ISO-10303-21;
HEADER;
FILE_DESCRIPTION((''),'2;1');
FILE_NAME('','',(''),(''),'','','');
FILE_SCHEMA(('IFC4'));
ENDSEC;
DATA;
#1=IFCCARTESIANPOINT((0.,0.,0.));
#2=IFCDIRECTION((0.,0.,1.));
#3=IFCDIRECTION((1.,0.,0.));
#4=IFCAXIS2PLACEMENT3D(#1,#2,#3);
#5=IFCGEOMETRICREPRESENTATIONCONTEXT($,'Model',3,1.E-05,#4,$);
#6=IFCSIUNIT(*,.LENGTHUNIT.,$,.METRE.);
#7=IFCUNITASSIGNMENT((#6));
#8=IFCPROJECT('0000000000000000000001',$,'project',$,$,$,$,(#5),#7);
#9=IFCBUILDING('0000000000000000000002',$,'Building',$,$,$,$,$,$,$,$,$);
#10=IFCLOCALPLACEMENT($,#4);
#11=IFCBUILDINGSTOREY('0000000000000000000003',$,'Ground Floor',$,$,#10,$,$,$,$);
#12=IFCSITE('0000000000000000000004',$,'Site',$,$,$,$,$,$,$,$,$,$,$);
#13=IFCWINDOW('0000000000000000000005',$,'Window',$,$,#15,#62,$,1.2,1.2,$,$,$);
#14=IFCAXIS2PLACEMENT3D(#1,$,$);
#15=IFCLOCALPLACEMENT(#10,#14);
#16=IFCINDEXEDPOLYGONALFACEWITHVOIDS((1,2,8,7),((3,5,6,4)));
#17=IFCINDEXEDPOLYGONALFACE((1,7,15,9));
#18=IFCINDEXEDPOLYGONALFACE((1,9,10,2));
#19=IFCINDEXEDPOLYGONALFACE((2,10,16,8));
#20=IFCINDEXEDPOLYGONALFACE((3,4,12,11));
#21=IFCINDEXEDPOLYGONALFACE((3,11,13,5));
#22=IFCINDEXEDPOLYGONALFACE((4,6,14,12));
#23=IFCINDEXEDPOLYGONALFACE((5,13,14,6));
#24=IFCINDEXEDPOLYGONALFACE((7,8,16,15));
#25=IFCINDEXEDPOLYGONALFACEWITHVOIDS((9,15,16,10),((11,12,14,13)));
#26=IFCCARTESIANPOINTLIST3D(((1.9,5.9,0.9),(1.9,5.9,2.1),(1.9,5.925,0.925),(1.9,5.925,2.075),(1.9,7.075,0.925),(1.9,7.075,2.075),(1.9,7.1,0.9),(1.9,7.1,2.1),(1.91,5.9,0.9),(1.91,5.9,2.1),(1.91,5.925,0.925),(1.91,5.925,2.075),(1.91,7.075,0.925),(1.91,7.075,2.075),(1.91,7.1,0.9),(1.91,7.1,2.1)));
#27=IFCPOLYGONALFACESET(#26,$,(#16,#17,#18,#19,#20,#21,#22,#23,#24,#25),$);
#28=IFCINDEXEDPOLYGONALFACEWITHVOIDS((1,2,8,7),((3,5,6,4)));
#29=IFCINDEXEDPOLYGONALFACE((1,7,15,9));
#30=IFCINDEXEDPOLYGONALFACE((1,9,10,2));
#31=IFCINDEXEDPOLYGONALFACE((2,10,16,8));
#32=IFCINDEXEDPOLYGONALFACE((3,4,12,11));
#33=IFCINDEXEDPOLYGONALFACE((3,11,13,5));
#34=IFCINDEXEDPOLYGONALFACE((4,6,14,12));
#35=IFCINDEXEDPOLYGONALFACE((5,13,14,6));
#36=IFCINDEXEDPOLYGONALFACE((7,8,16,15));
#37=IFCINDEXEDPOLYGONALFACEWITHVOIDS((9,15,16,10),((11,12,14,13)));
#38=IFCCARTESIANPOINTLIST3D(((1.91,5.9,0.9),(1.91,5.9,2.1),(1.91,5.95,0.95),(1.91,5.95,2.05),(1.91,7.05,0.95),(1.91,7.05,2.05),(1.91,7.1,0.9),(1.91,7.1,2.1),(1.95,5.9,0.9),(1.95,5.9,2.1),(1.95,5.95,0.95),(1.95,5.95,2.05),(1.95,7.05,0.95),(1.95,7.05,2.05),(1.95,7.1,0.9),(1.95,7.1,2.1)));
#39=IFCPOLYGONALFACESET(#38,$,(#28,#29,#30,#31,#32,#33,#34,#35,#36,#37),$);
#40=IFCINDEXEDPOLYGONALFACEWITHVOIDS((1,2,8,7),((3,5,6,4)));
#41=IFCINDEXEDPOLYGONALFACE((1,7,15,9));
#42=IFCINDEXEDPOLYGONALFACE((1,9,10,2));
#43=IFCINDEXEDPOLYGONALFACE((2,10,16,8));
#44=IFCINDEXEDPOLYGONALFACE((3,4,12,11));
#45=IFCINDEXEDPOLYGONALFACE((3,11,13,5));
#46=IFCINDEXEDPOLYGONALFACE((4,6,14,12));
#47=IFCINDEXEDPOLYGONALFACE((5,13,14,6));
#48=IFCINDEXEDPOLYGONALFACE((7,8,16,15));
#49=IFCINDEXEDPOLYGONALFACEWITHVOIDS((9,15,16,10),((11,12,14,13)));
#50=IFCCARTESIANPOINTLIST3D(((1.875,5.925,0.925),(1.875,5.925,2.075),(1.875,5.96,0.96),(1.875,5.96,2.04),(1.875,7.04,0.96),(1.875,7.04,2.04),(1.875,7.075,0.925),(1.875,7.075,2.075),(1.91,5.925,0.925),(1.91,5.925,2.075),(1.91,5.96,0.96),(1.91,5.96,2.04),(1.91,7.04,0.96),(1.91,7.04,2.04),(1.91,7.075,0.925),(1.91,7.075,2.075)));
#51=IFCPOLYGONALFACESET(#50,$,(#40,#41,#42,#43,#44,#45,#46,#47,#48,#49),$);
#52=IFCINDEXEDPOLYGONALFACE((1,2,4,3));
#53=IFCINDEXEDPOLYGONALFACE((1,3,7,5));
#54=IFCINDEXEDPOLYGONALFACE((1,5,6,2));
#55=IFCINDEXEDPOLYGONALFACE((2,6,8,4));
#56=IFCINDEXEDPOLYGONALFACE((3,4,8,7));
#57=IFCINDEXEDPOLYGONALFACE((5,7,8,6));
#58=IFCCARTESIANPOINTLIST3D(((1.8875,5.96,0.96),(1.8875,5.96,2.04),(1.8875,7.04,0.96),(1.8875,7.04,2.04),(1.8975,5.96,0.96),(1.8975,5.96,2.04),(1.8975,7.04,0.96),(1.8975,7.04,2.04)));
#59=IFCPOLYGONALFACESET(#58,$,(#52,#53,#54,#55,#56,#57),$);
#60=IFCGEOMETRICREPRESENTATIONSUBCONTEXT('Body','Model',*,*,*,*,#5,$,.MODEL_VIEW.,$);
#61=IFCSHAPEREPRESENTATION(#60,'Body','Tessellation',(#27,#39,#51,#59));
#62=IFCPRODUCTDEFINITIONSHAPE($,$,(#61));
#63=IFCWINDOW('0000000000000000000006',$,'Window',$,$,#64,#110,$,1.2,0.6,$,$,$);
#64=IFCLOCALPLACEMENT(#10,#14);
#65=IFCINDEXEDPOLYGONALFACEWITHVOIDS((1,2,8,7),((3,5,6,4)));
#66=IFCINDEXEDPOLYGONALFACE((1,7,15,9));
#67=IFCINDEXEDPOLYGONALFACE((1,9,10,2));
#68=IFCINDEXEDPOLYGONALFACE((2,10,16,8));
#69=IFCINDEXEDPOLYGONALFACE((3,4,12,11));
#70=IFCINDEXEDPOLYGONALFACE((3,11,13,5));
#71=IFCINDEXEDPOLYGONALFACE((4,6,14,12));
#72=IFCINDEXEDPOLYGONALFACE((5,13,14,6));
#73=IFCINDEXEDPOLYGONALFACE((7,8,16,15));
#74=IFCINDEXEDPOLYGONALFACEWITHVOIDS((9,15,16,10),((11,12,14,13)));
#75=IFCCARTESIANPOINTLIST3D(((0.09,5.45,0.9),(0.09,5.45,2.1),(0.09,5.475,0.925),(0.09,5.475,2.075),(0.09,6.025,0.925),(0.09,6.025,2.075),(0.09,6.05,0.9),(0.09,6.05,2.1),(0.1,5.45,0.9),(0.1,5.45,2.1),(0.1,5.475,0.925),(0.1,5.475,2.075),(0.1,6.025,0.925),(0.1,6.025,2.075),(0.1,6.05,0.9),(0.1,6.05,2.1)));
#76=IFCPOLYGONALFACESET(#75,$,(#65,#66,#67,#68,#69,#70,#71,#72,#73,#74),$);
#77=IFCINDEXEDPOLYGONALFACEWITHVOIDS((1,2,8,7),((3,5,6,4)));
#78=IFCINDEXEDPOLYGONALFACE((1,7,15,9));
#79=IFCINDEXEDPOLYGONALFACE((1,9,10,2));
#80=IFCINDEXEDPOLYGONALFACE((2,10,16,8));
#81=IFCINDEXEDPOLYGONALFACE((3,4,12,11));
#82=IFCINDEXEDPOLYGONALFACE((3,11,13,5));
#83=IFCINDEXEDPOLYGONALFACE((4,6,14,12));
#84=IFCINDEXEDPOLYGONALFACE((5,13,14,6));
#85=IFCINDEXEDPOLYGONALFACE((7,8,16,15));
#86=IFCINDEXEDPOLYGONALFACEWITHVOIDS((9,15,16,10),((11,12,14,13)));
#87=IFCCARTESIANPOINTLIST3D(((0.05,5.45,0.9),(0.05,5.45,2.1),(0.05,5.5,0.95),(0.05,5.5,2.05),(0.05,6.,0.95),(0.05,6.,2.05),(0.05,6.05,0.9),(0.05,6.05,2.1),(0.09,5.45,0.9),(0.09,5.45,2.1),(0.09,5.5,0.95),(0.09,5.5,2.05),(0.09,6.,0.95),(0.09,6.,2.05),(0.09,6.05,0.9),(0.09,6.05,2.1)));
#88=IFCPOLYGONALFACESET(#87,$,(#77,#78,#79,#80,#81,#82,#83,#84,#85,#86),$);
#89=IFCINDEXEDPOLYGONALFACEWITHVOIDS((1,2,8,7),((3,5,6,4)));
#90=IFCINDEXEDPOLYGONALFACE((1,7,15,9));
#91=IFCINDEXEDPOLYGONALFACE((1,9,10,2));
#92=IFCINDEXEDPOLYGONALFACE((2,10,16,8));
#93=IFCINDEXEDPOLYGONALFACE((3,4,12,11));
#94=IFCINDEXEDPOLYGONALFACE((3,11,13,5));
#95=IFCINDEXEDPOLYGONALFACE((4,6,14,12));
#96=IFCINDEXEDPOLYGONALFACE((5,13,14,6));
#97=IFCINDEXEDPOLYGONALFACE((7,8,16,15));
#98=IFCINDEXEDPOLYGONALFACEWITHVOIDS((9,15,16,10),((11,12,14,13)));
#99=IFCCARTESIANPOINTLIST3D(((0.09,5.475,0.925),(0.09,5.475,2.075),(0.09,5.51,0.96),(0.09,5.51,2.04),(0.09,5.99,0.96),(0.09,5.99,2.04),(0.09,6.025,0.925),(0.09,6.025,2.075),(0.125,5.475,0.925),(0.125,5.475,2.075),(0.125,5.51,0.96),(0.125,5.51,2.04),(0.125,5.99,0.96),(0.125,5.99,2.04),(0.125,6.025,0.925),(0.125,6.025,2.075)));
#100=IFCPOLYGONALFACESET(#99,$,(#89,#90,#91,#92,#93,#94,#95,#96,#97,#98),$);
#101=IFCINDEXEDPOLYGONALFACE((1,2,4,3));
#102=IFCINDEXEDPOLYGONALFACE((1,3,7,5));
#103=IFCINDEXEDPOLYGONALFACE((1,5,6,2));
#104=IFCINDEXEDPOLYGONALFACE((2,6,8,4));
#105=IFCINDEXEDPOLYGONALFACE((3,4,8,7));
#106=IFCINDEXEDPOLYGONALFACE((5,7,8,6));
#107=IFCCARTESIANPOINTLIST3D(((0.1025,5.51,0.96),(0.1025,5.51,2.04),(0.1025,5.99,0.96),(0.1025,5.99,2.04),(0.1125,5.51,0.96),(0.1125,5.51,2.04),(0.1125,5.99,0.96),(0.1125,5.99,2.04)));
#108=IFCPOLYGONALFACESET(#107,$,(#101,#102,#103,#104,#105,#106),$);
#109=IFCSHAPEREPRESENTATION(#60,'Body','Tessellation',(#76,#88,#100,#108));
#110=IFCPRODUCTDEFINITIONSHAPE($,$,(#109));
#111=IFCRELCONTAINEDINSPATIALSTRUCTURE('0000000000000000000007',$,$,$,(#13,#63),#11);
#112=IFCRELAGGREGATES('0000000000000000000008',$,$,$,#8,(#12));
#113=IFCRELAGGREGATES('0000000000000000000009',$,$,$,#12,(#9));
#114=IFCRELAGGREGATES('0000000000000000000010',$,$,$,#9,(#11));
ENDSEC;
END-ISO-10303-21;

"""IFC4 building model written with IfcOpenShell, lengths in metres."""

from ifc_helpers import new_model, si_unit, frame, origin_with_axes, place, context, subcontext, project, spatial, line, indexed_curve, outline, extrude, element, save


model = new_model("IFC4")

# Units and contexts
model_context = context("Model", 3, precision=1e-05, world=origin_with_axes())
body_context = subcontext(model_context, "Body", "Model", "MODEL_VIEW")
ifc_project = project(units=[si_unit("LENGTHUNIT", "METRE")], contexts=[model_context])

# Site, building, storey
site = spatial("IfcSite", under=ifc_project, Name="Site")
building = spatial("IfcBuilding", under=site, Name="Building")
storey_placement = place(None, origin_with_axes())
storey = spatial("IfcBuildingStorey", under=building, at=storey_placement, Name="Ground Floor")

# Windows
window_1_placement = place(storey_placement, frame((2.0, 5.9, 0.9), z_axis=(0.0, 0.0, 1.0), x_axis=(0.0, 1.0, 0.0)))
element("IfcWindow", 1, at=window_1_placement, inside=storey, Name="Window", OverallHeight=1.2, OverallWidth=1.2, context=body_context, shape_type="SweptSolid", body=[
    extrude(outline(indexed_curve([(0.0, 0.0), (1.2, 0.0), (1.2, 1.2), (0.0, 1.2)], segments=[line(1, 2, 3, 4, 1)]), holes=[indexed_curve([(0.025, 0.025), (1.175, 0.025), (1.175, 1.175), (0.025, 1.175)], segments=[line(1, 2, 3, 4, 1)])]), frame((0.0, 0.09, 0.0), z_axis=(0.0, -1.0, 0.0), x_axis=(1.0, 0.0, 0.0)), (0.0, 0.0, -1.0), 0.01),
    extrude(outline(indexed_curve([(0.0, 0.0), (1.2, 0.0), (1.2, 1.2), (0.0, 1.2)], segments=[line(1, 2, 3, 4, 1)]), holes=[indexed_curve([(0.05, 0.05), (1.15, 0.05), (1.15, 1.15), (0.05, 1.15)], segments=[line(1, 2, 3, 4, 1)])]), frame((0.0, 0.05, 0.0), z_axis=(0.0, -1.0, 0.0), x_axis=(1.0, 0.0, 0.0)), (0.0, 0.0, -1.0), 0.04),
    extrude(outline(indexed_curve([(0.0, 0.0), (1.15, 0.0), (1.15, 1.15), (0.0, 1.15)], segments=[line(1, 2, 3, 4, 1)]), holes=[indexed_curve([(0.035, 0.035), (1.115, 0.035), (1.115, 1.115), (0.035, 1.115)], segments=[line(1, 2, 3, 4, 1)])]), frame((0.025, 0.09, 0.025), z_axis=(0.0, -1.0, 0.0), x_axis=(1.0, 0.0, 0.0)), (0.0, 0.0, -1.0), 0.035),
    extrude(outline(indexed_curve([(0.035, 0.035), (1.115, 0.035), (1.115, 1.115), (0.035, 1.115)], segments=[line(1, 2, 3, 4, 1)])), frame((0.025, 0.1025, 0.025), z_axis=(0.0, -1.0, 0.0), x_axis=(1.0, 0.0, 0.0)), (0.0, 0.0, -1.0), 0.01),
])
window_2_placement = place(storey_placement, frame((0.0, 6.05, 0.9), z_axis=(0.0, 0.0, 1.0), x_axis=(0.0, -1.0, 0.0)))
element("IfcWindow", 2, at=window_2_placement, inside=storey, Name="Window", OverallHeight=1.2, OverallWidth=0.6, context=body_context, shape_type="SweptSolid", body=[
    extrude(outline(indexed_curve([(0.0, 0.0), (0.6, 0.0), (0.6, 1.2), (0.0, 1.2)], segments=[line(1, 2, 3, 4, 1)]), holes=[indexed_curve([(0.025, 0.025), (0.575, 0.025), (0.575, 1.175), (0.025, 1.175)], segments=[line(1, 2, 3, 4, 1)])]), frame((0.0, 0.09, 0.0), z_axis=(0.0, -1.0, 0.0), x_axis=(1.0, 0.0, 0.0)), (0.0, 0.0, -1.0), 0.01),
    extrude(outline(indexed_curve([(0.0, 0.0), (0.6, 0.0), (0.6, 1.2), (0.0, 1.2)], segments=[line(1, 2, 3, 4, 1)]), holes=[indexed_curve([(0.05, 0.05), (0.55, 0.05), (0.55, 1.15), (0.05, 1.15)], segments=[line(1, 2, 3, 4, 1)])]), frame((0.0, 0.05, 0.0), z_axis=(0.0, -1.0, 0.0), x_axis=(1.0, 0.0, 0.0)), (0.0, 0.0, -1.0), 0.04),
    extrude(outline(indexed_curve([(0.0, 0.0), (0.55, 0.0), (0.55, 1.15), (0.0, 1.15)], segments=[line(1, 2, 3, 4, 1)]), holes=[indexed_curve([(0.035, 0.035), (0.515, 0.035), (0.515, 1.115), (0.035, 1.115)], segments=[line(1, 2, 3, 4, 1)])]), frame((0.025, 0.09, 0.025), z_axis=(0.0, -1.0, 0.0), x_axis=(1.0, 0.0, 0.0)), (0.0, 0.0, -1.0), 0.035),
    extrude(outline(indexed_curve([(0.035, 0.035), (0.515, 0.035), (0.515, 1.115), (0.035, 1.115)], segments=[line(1, 2, 3, 4, 1)])), frame((0.025, 0.1025, 0.025), z_axis=(0.0, -1.0, 0.0), x_axis=(1.0, 0.0, 0.0)), (0.0, 0.0, -1.0), 0.01),
])

save(model, "model.ifc")
